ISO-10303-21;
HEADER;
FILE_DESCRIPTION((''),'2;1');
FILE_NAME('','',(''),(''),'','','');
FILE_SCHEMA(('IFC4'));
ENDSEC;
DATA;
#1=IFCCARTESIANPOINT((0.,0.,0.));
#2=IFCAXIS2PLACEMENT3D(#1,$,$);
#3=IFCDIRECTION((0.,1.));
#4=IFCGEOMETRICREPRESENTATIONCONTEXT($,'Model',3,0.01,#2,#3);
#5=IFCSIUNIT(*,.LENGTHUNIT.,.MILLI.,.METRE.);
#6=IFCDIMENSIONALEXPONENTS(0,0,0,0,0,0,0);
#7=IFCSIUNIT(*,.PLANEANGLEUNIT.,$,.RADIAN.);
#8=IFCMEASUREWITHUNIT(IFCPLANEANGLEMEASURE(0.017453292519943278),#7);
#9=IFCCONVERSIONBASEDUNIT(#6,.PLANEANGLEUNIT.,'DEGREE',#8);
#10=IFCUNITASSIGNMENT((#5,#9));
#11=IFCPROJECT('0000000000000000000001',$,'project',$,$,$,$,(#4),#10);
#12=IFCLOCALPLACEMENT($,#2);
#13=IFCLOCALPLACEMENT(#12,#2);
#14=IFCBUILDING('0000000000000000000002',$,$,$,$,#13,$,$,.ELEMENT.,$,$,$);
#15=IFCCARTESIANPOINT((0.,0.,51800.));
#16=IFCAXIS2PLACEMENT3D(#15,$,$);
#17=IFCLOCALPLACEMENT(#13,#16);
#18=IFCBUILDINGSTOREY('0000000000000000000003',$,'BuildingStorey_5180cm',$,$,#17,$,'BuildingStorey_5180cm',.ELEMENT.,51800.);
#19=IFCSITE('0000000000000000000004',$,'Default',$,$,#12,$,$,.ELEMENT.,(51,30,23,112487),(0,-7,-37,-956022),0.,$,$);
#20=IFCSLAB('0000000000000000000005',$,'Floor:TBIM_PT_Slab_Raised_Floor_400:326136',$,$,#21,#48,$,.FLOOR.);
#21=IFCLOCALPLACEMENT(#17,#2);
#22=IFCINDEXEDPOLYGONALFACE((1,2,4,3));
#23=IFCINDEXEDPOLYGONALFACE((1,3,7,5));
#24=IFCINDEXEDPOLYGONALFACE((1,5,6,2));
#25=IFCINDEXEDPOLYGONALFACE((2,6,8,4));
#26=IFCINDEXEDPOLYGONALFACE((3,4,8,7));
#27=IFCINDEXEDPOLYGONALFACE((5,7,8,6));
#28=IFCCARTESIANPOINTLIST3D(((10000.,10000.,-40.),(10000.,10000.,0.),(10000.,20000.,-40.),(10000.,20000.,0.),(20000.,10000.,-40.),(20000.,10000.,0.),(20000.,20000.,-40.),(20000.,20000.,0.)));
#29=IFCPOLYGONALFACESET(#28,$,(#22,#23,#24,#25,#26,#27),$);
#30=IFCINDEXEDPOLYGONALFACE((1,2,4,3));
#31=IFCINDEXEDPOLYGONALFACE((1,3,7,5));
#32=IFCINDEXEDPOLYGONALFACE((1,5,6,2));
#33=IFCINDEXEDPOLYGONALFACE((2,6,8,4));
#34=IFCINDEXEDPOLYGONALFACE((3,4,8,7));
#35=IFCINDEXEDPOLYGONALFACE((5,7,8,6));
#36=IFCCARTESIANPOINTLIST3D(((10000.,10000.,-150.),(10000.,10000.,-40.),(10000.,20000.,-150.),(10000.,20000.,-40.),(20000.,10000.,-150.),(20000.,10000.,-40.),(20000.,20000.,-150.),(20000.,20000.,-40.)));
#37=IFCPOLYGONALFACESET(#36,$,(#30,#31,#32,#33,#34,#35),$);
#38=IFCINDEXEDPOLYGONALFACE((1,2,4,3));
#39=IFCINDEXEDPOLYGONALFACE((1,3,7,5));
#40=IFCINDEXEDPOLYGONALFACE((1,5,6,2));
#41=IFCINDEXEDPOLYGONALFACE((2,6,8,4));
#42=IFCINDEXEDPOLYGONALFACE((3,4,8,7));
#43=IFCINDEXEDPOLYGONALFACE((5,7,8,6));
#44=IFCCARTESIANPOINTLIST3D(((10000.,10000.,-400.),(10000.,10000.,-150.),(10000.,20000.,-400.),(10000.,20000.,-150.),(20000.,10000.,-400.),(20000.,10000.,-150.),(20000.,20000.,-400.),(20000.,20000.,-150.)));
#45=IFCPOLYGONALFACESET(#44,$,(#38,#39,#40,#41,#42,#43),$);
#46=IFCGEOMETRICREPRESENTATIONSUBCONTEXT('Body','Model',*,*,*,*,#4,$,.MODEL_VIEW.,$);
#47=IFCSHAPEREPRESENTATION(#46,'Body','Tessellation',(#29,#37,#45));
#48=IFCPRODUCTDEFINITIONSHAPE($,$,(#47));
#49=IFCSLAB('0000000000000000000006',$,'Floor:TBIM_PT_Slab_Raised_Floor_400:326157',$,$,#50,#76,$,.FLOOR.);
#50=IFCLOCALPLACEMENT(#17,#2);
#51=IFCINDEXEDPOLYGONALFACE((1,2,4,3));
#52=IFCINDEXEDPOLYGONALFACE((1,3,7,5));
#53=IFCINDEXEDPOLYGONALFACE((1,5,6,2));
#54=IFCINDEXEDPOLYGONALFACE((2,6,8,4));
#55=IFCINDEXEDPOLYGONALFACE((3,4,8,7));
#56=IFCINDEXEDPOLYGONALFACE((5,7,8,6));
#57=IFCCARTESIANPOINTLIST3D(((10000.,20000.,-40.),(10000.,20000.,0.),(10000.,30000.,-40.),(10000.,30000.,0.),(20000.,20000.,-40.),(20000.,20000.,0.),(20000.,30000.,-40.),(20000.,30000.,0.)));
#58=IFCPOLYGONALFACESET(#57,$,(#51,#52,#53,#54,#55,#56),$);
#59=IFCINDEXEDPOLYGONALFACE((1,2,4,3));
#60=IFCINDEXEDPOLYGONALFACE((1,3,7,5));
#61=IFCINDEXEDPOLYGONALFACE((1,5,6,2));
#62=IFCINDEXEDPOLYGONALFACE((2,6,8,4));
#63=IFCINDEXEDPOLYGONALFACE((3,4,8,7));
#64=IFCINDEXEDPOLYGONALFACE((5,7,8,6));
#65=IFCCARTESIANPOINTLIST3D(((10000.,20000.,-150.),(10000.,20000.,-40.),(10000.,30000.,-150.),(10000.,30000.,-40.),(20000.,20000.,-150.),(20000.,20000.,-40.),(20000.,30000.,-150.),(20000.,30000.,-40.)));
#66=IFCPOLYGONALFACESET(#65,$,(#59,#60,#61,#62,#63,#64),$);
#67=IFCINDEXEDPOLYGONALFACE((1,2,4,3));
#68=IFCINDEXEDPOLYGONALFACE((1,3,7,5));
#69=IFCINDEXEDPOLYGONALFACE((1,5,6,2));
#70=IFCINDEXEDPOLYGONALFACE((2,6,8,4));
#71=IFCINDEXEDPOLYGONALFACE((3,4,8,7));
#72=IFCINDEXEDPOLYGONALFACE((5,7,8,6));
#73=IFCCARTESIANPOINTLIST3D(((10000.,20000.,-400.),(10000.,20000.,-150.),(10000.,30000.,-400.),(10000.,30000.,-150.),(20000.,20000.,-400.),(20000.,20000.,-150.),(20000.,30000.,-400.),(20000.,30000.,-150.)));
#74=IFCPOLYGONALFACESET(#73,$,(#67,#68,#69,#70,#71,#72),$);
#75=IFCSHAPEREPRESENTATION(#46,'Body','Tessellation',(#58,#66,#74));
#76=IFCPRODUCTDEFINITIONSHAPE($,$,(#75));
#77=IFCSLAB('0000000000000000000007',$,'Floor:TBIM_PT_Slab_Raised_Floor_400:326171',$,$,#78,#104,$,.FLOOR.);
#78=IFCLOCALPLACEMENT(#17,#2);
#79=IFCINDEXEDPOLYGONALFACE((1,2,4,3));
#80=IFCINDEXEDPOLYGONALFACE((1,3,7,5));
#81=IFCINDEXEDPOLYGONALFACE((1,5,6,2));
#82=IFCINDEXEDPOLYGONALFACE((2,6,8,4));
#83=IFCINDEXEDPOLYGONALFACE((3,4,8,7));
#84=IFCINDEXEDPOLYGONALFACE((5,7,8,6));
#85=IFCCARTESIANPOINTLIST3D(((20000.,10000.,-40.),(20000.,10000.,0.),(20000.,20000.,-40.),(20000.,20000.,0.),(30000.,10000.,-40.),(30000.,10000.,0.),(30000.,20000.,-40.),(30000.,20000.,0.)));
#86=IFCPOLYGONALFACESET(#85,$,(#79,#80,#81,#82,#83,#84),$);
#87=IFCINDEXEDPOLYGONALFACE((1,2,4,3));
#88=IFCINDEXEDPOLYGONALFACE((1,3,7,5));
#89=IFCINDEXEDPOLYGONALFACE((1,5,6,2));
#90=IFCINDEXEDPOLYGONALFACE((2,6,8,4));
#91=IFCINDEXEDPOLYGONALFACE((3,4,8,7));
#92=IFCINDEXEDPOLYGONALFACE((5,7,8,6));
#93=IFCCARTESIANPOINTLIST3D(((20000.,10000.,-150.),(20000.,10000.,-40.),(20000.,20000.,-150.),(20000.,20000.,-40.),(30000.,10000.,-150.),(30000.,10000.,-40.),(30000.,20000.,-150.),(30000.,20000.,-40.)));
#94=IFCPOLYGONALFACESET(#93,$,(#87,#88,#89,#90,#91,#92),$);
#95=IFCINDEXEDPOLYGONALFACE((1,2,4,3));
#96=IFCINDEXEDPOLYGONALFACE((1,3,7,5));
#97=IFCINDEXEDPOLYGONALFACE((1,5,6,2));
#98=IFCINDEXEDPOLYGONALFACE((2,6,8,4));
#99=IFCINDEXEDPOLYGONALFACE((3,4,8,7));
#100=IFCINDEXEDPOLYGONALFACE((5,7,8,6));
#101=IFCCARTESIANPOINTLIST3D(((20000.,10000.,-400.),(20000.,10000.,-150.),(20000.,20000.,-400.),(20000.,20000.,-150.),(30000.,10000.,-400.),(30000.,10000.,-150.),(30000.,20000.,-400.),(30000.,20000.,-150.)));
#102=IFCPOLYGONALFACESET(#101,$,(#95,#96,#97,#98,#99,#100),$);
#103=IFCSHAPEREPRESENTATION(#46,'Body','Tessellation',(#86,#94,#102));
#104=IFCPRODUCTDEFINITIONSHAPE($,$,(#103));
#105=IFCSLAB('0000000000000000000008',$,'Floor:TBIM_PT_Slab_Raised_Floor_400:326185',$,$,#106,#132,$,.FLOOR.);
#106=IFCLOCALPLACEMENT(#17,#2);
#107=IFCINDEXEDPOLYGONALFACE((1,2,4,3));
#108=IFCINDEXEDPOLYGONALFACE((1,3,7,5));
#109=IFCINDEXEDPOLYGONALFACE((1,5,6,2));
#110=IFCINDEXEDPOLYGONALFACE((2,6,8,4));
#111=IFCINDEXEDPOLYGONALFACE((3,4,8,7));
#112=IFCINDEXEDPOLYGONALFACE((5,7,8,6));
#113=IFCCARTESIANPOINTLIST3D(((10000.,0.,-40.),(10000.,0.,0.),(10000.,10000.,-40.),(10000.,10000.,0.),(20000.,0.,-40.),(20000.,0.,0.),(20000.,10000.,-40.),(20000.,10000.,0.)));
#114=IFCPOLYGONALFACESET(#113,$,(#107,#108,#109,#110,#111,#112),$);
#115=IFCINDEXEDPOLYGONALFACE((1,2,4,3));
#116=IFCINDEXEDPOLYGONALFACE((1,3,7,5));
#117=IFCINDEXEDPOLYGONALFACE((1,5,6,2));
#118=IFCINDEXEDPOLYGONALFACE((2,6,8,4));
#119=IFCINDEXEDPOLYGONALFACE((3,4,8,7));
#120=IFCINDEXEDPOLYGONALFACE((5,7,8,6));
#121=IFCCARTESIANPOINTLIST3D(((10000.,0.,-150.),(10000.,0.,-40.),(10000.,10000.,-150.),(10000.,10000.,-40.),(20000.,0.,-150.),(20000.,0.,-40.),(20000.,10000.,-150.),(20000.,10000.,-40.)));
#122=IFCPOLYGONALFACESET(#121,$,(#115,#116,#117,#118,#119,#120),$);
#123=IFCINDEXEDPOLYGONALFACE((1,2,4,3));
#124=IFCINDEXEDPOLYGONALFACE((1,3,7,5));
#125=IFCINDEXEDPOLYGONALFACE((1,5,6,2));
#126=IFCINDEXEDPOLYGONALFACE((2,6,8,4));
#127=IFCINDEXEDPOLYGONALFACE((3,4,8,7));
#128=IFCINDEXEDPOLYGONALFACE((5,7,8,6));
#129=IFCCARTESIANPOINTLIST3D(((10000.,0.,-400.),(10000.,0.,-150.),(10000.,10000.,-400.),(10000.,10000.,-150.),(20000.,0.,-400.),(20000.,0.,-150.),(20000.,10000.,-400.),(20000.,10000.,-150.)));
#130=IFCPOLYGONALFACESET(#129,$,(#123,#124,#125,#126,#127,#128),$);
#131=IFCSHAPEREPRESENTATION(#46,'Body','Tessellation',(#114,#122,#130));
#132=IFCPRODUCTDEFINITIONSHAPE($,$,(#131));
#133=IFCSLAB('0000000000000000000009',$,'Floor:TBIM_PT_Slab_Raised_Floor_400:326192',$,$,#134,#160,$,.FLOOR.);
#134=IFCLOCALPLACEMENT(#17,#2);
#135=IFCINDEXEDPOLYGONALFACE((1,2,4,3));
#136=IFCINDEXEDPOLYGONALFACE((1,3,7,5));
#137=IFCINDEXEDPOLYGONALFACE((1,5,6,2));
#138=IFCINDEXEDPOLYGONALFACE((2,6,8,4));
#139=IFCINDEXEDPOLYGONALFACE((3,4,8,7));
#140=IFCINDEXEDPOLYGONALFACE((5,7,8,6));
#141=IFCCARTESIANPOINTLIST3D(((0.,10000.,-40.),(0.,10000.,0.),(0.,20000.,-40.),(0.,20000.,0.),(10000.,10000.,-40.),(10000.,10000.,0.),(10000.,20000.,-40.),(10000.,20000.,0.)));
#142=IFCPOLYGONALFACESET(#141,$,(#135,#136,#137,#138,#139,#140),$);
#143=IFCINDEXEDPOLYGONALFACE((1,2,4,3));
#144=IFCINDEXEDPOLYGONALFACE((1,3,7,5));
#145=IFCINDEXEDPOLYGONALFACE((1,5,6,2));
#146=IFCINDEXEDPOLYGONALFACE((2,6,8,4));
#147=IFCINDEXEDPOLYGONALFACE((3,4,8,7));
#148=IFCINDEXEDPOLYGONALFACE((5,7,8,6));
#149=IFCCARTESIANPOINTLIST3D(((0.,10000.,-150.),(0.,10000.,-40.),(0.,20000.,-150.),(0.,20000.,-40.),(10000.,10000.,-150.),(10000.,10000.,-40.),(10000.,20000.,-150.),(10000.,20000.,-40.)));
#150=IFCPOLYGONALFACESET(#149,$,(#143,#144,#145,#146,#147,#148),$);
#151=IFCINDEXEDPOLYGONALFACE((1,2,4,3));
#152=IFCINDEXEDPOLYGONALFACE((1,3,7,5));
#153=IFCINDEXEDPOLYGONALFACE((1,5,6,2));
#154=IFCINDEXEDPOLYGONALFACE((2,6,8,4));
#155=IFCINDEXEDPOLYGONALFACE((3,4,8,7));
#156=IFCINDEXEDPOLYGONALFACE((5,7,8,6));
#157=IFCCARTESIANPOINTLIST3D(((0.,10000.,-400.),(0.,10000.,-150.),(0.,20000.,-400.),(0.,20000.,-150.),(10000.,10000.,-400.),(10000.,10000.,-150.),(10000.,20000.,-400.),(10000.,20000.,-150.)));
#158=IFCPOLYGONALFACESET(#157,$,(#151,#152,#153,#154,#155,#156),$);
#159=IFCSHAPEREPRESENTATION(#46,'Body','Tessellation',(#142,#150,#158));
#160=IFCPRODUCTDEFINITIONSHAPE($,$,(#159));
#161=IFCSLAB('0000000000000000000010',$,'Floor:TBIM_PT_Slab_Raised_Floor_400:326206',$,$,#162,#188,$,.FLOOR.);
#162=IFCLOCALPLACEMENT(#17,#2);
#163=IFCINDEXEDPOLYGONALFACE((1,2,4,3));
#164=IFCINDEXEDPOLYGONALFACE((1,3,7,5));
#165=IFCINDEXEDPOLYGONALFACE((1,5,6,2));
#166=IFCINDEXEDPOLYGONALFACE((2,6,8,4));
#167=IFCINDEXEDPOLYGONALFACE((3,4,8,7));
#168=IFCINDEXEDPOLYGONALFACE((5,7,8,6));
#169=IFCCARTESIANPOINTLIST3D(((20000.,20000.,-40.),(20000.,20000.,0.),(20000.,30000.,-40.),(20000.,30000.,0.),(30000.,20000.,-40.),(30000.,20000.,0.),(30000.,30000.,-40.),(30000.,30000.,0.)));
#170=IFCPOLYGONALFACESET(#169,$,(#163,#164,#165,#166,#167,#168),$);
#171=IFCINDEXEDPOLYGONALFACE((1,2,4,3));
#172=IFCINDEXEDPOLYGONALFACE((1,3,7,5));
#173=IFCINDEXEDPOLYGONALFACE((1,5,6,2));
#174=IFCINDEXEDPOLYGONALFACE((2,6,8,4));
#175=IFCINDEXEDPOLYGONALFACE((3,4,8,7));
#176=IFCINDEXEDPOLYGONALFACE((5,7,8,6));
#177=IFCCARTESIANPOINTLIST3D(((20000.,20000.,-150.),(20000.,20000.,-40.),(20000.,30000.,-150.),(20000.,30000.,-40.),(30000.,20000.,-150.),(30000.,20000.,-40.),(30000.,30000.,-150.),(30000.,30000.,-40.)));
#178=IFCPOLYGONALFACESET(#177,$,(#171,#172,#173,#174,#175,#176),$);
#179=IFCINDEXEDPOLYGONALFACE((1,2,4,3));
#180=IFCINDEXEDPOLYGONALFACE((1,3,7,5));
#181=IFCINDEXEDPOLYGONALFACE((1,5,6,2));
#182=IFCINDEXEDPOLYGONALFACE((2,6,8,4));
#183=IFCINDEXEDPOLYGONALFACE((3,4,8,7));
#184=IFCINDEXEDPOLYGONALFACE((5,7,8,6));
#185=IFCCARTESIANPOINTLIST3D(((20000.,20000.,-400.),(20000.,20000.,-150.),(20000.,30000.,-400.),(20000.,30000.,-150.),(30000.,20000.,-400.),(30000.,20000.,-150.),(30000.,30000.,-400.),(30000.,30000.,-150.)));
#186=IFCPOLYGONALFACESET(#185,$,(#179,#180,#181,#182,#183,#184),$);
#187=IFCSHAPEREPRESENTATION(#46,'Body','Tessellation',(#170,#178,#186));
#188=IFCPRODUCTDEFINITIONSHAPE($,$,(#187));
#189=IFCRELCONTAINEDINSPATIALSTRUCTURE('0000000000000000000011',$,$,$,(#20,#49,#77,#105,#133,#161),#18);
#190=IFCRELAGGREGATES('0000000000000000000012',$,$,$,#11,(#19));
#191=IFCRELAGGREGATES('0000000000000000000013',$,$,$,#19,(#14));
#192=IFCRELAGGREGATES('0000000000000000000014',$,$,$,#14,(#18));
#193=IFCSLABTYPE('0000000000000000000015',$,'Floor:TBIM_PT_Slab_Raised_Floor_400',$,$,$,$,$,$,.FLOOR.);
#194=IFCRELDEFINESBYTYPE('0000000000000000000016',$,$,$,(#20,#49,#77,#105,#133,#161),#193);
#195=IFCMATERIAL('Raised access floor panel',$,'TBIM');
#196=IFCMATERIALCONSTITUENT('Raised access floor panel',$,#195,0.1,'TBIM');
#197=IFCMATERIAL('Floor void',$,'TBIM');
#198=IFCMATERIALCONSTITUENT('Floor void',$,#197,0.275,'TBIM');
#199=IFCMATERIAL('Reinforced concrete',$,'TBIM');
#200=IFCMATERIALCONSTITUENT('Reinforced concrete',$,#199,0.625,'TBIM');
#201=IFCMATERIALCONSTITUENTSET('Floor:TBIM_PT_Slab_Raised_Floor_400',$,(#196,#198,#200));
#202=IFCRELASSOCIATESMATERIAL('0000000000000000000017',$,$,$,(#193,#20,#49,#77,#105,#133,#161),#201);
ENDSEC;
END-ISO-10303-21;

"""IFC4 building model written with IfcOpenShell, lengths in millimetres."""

from ifc_helpers import new_model, entity, si_unit, converted_unit, direction, frame, origin, place, context, subcontext, project, spatial, indexed_curve, outline, extrude, material, constituent, constituent_set, type_object, element, save


model = new_model("IFC4")

# Units and contexts
model_context = context("Model", 3, precision=0.01, world=origin(), true_north=direction((0.0, 1.0)))
body_context = subcontext(model_context, "Body", "Model", "MODEL_VIEW")
ifc_project = project(units=[si_unit("LENGTHUNIT", "METRE", prefix="MILLI"), converted_unit("PLANEANGLEUNIT", "DEGREE", entity("IfcPlaneAngleMeasure", 0.017453292519943278), si_unit("PLANEANGLEUNIT", "RADIAN"), dimensions=[0, 0, 0, 0, 0, 0, 0])], contexts=[model_context])

# Site, building, storey
site_placement = place(None, origin())
site = spatial("IfcSite", under=ifc_project, at=site_placement, Name="Default", CompositionType="ELEMENT", RefLatitude=(51, 30, 23, 112487), RefLongitude=(0, -7, -37, -956022), RefElevation=0.0)
building_placement = place(site_placement, origin())
building = spatial("IfcBuilding", under=site, at=building_placement, CompositionType="ELEMENT")
storey_placement = place(building_placement, frame((0.0, 0.0, 51800.0)))
storey = spatial("IfcBuildingStorey", under=building, at=storey_placement, Name="BuildingStorey_5180cm", LongName="BuildingStorey_5180cm", CompositionType="ELEMENT", Elevation=51800.0)

# Slabs
ifc_material_1 = material(Name="Raised access floor panel", Category="TBIM")
ifc_constituent_1 = constituent(ifc_material_1, Name="Raised access floor panel", Category="TBIM", fraction=0.1)
ifc_material_2 = material(Name="Floor void", Category="TBIM")
ifc_constituent_2 = constituent(ifc_material_2, Name="Floor void", Category="TBIM", fraction=0.275)
ifc_material_3 = material(Name="Reinforced concrete", Category="TBIM")
ifc_constituent_3 = constituent(ifc_material_3, Name="Reinforced concrete", Category="TBIM", fraction=0.625)
ifc_constituent_set_1 = constituent_set(constituents=[ifc_constituent_1, ifc_constituent_2, ifc_constituent_3], Name="Floor:TBIM_PT_Slab_Raised_Floor_400")
slab_type = type_object("IfcSlabType", Name="Floor:TBIM_PT_Slab_Raised_Floor_400", PredefinedType="FLOOR", material=ifc_constituent_set_1)
slab_1_placement = place(storey_placement, origin())
element("IfcSlab", 1, at=slab_1_placement, inside=storey, type_object=slab_type, material=ifc_constituent_set_1, Name="Floor:TBIM_PT_Slab_Raised_Floor_400:326136", PredefinedType="FLOOR", context=body_context, shape_type="SweptSolid", body=[
    extrude(outline(indexed_curve([(-5000.0, -5000.0), (5000.0, -5000.0), (5000.0, 5000.0), (-5000.0, 5000.0), (-5000.0, -5000.0)], self_intersect=False)), frame((15000.0, 15000.0, -40.0), z_axis=(0.0, 0.0, 1.0), x_axis=(-1.0, 0.0, 0.0)), (0.0, 0.0, 1.0), 40.0),
    extrude(outline(indexed_curve([(-5000.0, -5000.0), (5000.0, -5000.0), (5000.0, 5000.0), (-5000.0, 5000.0), (-5000.0, -5000.0)], self_intersect=False)), frame((15000.0, 15000.0, -150.0), z_axis=(0.0, 0.0, 1.0), x_axis=(-1.0, 0.0, 0.0)), (0.0, 0.0, 1.0), 110.0),
    extrude(outline(indexed_curve([(-5000.0, -5000.0), (5000.0, -5000.0), (5000.0, 5000.0), (-5000.0, 5000.0), (-5000.0, -5000.0)], self_intersect=False)), frame((15000.0, 15000.0, -400.0), z_axis=(0.0, 0.0, 1.0), x_axis=(-1.0, 0.0, 0.0)), (0.0, 0.0, 1.0), 250.0),
])
slab_2_placement = place(storey_placement, origin())
element("IfcSlab", 2, at=slab_2_placement, inside=storey, type_object=slab_type, material=ifc_constituent_set_1, Name="Floor:TBIM_PT_Slab_Raised_Floor_400:326157", PredefinedType="FLOOR", context=body_context, shape_type="SweptSolid", body=[
    extrude(outline(indexed_curve([(-5000.0, -5000.0), (5000.0, -5000.0), (5000.0, 5000.0), (-5000.0, 5000.0), (-5000.0, -5000.0)], self_intersect=False)), frame((15000.0, 25000.0, -40.0), z_axis=(0.0, 0.0, 1.0), x_axis=(-1.0, 0.0, 0.0)), (0.0, 0.0, 1.0), 40.0),
    extrude(outline(indexed_curve([(-5000.0, -5000.0), (5000.0, -5000.0), (5000.0, 5000.0), (-5000.0, 5000.0), (-5000.0, -5000.0)], self_intersect=False)), frame((15000.0, 25000.0, -150.0), z_axis=(0.0, 0.0, 1.0), x_axis=(-1.0, 0.0, 0.0)), (0.0, 0.0, 1.0), 110.0),
    extrude(outline(indexed_curve([(-5000.0, -5000.0), (5000.0, -5000.0), (5000.0, 5000.0), (-5000.0, 5000.0), (-5000.0, -5000.0)], self_intersect=False)), frame((15000.0, 25000.0, -400.0), z_axis=(0.0, 0.0, 1.0), x_axis=(-1.0, 0.0, 0.0)), (0.0, 0.0, 1.0), 250.0),
])
slab_3_placement = place(storey_placement, origin())
element("IfcSlab", 3, at=slab_3_placement, inside=storey, type_object=slab_type, material=ifc_constituent_set_1, Name="Floor:TBIM_PT_Slab_Raised_Floor_400:326171", PredefinedType="FLOOR", context=body_context, shape_type="SweptSolid", body=[
    extrude(outline(indexed_curve([(-5000.0, -5000.0), (5000.0, -5000.0), (5000.0, 5000.0), (-5000.0, 5000.0), (-5000.0, -5000.0)], self_intersect=False)), frame((25000.0, 15000.0, -40.0), z_axis=(0.0, 0.0, 1.0), x_axis=(-1.0, 0.0, 0.0)), (0.0, 0.0, 1.0), 40.0),
    extrude(outline(indexed_curve([(-5000.0, -5000.0), (5000.0, -5000.0), (5000.0, 5000.0), (-5000.0, 5000.0), (-5000.0, -5000.0)], self_intersect=False)), frame((25000.0, 15000.0, -150.0), z_axis=(0.0, 0.0, 1.0), x_axis=(-1.0, 0.0, 0.0)), (0.0, 0.0, 1.0), 110.0),
    extrude(outline(indexed_curve([(-5000.0, -5000.0), (5000.0, -5000.0), (5000.0, 5000.0), (-5000.0, 5000.0), (-5000.0, -5000.0)], self_intersect=False)), frame((25000.0, 15000.0, -400.0), z_axis=(0.0, 0.0, 1.0), x_axis=(-1.0, 0.0, 0.0)), (0.0, 0.0, 1.0), 250.0),
])
slab_4_placement = place(storey_placement, origin())
element("IfcSlab", 4, at=slab_4_placement, inside=storey, type_object=slab_type, material=ifc_constituent_set_1, Name="Floor:TBIM_PT_Slab_Raised_Floor_400:326185", PredefinedType="FLOOR", context=body_context, shape_type="SweptSolid", body=[
    extrude(outline(indexed_curve([(-5000.0, -5000.0), (5000.0, -5000.0), (5000.0, 5000.0), (-5000.0, 5000.0), (-5000.0, -5000.0)], self_intersect=False)), frame((15000.0, 5000.0, -40.0), z_axis=(0.0, 0.0, 1.0), x_axis=(0.0, 1.0, 0.0)), (0.0, 0.0, 1.0), 40.0),
    extrude(outline(indexed_curve([(-5000.0, -5000.0), (5000.0, -5000.0), (5000.0, 5000.0), (-5000.0, 5000.0), (-5000.0, -5000.0)], self_intersect=False)), frame((15000.0, 5000.0, -150.0), z_axis=(0.0, 0.0, 1.0), x_axis=(0.0, 1.0, 0.0)), (0.0, 0.0, 1.0), 110.0),
    extrude(outline(indexed_curve([(-5000.0, -5000.0), (5000.0, -5000.0), (5000.0, 5000.0), (-5000.0, 5000.0), (-5000.0, -5000.0)], self_intersect=False)), frame((15000.0, 5000.0, -400.0), z_axis=(0.0, 0.0, 1.0), x_axis=(0.0, 1.0, 0.0)), (0.0, 0.0, 1.0), 250.0),
])
slab_5_placement = place(storey_placement, origin())
element("IfcSlab", 5, at=slab_5_placement, inside=storey, type_object=slab_type, material=ifc_constituent_set_1, Name="Floor:TBIM_PT_Slab_Raised_Floor_400:326192", PredefinedType="FLOOR", context=body_context, shape_type="SweptSolid", body=[
    extrude(outline(indexed_curve([(-5000.0, -5000.0), (5000.0, -5000.0), (5000.0, 5000.0), (-5000.0, 5000.0), (-5000.0, -5000.0)], self_intersect=False)), frame((5000.0, 15000.0, -40.0), z_axis=(0.0, 0.0, 1.0), x_axis=(0.0, 1.0, 0.0)), (0.0, 0.0, 1.0), 40.0),
    extrude(outline(indexed_curve([(-5000.0, -5000.0), (5000.0, -5000.0), (5000.0, 5000.0), (-5000.0, 5000.0), (-5000.0, -5000.0)], self_intersect=False)), frame((5000.0, 15000.0, -150.0), z_axis=(0.0, 0.0, 1.0), x_axis=(0.0, 1.0, 0.0)), (0.0, 0.0, 1.0), 110.0),
    extrude(outline(indexed_curve([(-5000.0, -5000.0), (5000.0, -5000.0), (5000.0, 5000.0), (-5000.0, 5000.0), (-5000.0, -5000.0)], self_intersect=False)), frame((5000.0, 15000.0, -400.0), z_axis=(0.0, 0.0, 1.0), x_axis=(0.0, 1.0, 0.0)), (0.0, 0.0, 1.0), 250.0),
])
slab_6_placement = place(storey_placement, origin())
element("IfcSlab", 6, at=slab_6_placement, inside=storey, type_object=slab_type, material=ifc_constituent_set_1, Name="Floor:TBIM_PT_Slab_Raised_Floor_400:326206", PredefinedType="FLOOR", context=body_context, shape_type="SweptSolid", body=[
    extrude(outline(indexed_curve([(-5000.0, -5000.0), (5000.0, -5000.0), (5000.0, 5000.0), (-5000.0, 5000.0), (-5000.0, -5000.0)], self_intersect=False)), frame((25000.0, 25000.0, -40.0), z_axis=(0.0, 0.0, 1.0), x_axis=(-1.0, 0.0, 0.0)), (0.0, 0.0, 1.0), 40.0),
    extrude(outline(indexed_curve([(-5000.0, -5000.0), (5000.0, -5000.0), (5000.0, 5000.0), (-5000.0, 5000.0), (-5000.0, -5000.0)], self_intersect=False)), frame((25000.0, 25000.0, -150.0), z_axis=(0.0, 0.0, 1.0), x_axis=(-1.0, 0.0, 0.0)), (0.0, 0.0, 1.0), 110.0),
    extrude(outline(indexed_curve([(-5000.0, -5000.0), (5000.0, -5000.0), (5000.0, 5000.0), (-5000.0, 5000.0), (-5000.0, -5000.0)], self_intersect=False)), frame((25000.0, 25000.0, -400.0), z_axis=(0.0, 0.0, 1.0), x_axis=(-1.0, 0.0, 0.0)), (0.0, 0.0, 1.0), 250.0),
])

save(model, "model.ifc")
